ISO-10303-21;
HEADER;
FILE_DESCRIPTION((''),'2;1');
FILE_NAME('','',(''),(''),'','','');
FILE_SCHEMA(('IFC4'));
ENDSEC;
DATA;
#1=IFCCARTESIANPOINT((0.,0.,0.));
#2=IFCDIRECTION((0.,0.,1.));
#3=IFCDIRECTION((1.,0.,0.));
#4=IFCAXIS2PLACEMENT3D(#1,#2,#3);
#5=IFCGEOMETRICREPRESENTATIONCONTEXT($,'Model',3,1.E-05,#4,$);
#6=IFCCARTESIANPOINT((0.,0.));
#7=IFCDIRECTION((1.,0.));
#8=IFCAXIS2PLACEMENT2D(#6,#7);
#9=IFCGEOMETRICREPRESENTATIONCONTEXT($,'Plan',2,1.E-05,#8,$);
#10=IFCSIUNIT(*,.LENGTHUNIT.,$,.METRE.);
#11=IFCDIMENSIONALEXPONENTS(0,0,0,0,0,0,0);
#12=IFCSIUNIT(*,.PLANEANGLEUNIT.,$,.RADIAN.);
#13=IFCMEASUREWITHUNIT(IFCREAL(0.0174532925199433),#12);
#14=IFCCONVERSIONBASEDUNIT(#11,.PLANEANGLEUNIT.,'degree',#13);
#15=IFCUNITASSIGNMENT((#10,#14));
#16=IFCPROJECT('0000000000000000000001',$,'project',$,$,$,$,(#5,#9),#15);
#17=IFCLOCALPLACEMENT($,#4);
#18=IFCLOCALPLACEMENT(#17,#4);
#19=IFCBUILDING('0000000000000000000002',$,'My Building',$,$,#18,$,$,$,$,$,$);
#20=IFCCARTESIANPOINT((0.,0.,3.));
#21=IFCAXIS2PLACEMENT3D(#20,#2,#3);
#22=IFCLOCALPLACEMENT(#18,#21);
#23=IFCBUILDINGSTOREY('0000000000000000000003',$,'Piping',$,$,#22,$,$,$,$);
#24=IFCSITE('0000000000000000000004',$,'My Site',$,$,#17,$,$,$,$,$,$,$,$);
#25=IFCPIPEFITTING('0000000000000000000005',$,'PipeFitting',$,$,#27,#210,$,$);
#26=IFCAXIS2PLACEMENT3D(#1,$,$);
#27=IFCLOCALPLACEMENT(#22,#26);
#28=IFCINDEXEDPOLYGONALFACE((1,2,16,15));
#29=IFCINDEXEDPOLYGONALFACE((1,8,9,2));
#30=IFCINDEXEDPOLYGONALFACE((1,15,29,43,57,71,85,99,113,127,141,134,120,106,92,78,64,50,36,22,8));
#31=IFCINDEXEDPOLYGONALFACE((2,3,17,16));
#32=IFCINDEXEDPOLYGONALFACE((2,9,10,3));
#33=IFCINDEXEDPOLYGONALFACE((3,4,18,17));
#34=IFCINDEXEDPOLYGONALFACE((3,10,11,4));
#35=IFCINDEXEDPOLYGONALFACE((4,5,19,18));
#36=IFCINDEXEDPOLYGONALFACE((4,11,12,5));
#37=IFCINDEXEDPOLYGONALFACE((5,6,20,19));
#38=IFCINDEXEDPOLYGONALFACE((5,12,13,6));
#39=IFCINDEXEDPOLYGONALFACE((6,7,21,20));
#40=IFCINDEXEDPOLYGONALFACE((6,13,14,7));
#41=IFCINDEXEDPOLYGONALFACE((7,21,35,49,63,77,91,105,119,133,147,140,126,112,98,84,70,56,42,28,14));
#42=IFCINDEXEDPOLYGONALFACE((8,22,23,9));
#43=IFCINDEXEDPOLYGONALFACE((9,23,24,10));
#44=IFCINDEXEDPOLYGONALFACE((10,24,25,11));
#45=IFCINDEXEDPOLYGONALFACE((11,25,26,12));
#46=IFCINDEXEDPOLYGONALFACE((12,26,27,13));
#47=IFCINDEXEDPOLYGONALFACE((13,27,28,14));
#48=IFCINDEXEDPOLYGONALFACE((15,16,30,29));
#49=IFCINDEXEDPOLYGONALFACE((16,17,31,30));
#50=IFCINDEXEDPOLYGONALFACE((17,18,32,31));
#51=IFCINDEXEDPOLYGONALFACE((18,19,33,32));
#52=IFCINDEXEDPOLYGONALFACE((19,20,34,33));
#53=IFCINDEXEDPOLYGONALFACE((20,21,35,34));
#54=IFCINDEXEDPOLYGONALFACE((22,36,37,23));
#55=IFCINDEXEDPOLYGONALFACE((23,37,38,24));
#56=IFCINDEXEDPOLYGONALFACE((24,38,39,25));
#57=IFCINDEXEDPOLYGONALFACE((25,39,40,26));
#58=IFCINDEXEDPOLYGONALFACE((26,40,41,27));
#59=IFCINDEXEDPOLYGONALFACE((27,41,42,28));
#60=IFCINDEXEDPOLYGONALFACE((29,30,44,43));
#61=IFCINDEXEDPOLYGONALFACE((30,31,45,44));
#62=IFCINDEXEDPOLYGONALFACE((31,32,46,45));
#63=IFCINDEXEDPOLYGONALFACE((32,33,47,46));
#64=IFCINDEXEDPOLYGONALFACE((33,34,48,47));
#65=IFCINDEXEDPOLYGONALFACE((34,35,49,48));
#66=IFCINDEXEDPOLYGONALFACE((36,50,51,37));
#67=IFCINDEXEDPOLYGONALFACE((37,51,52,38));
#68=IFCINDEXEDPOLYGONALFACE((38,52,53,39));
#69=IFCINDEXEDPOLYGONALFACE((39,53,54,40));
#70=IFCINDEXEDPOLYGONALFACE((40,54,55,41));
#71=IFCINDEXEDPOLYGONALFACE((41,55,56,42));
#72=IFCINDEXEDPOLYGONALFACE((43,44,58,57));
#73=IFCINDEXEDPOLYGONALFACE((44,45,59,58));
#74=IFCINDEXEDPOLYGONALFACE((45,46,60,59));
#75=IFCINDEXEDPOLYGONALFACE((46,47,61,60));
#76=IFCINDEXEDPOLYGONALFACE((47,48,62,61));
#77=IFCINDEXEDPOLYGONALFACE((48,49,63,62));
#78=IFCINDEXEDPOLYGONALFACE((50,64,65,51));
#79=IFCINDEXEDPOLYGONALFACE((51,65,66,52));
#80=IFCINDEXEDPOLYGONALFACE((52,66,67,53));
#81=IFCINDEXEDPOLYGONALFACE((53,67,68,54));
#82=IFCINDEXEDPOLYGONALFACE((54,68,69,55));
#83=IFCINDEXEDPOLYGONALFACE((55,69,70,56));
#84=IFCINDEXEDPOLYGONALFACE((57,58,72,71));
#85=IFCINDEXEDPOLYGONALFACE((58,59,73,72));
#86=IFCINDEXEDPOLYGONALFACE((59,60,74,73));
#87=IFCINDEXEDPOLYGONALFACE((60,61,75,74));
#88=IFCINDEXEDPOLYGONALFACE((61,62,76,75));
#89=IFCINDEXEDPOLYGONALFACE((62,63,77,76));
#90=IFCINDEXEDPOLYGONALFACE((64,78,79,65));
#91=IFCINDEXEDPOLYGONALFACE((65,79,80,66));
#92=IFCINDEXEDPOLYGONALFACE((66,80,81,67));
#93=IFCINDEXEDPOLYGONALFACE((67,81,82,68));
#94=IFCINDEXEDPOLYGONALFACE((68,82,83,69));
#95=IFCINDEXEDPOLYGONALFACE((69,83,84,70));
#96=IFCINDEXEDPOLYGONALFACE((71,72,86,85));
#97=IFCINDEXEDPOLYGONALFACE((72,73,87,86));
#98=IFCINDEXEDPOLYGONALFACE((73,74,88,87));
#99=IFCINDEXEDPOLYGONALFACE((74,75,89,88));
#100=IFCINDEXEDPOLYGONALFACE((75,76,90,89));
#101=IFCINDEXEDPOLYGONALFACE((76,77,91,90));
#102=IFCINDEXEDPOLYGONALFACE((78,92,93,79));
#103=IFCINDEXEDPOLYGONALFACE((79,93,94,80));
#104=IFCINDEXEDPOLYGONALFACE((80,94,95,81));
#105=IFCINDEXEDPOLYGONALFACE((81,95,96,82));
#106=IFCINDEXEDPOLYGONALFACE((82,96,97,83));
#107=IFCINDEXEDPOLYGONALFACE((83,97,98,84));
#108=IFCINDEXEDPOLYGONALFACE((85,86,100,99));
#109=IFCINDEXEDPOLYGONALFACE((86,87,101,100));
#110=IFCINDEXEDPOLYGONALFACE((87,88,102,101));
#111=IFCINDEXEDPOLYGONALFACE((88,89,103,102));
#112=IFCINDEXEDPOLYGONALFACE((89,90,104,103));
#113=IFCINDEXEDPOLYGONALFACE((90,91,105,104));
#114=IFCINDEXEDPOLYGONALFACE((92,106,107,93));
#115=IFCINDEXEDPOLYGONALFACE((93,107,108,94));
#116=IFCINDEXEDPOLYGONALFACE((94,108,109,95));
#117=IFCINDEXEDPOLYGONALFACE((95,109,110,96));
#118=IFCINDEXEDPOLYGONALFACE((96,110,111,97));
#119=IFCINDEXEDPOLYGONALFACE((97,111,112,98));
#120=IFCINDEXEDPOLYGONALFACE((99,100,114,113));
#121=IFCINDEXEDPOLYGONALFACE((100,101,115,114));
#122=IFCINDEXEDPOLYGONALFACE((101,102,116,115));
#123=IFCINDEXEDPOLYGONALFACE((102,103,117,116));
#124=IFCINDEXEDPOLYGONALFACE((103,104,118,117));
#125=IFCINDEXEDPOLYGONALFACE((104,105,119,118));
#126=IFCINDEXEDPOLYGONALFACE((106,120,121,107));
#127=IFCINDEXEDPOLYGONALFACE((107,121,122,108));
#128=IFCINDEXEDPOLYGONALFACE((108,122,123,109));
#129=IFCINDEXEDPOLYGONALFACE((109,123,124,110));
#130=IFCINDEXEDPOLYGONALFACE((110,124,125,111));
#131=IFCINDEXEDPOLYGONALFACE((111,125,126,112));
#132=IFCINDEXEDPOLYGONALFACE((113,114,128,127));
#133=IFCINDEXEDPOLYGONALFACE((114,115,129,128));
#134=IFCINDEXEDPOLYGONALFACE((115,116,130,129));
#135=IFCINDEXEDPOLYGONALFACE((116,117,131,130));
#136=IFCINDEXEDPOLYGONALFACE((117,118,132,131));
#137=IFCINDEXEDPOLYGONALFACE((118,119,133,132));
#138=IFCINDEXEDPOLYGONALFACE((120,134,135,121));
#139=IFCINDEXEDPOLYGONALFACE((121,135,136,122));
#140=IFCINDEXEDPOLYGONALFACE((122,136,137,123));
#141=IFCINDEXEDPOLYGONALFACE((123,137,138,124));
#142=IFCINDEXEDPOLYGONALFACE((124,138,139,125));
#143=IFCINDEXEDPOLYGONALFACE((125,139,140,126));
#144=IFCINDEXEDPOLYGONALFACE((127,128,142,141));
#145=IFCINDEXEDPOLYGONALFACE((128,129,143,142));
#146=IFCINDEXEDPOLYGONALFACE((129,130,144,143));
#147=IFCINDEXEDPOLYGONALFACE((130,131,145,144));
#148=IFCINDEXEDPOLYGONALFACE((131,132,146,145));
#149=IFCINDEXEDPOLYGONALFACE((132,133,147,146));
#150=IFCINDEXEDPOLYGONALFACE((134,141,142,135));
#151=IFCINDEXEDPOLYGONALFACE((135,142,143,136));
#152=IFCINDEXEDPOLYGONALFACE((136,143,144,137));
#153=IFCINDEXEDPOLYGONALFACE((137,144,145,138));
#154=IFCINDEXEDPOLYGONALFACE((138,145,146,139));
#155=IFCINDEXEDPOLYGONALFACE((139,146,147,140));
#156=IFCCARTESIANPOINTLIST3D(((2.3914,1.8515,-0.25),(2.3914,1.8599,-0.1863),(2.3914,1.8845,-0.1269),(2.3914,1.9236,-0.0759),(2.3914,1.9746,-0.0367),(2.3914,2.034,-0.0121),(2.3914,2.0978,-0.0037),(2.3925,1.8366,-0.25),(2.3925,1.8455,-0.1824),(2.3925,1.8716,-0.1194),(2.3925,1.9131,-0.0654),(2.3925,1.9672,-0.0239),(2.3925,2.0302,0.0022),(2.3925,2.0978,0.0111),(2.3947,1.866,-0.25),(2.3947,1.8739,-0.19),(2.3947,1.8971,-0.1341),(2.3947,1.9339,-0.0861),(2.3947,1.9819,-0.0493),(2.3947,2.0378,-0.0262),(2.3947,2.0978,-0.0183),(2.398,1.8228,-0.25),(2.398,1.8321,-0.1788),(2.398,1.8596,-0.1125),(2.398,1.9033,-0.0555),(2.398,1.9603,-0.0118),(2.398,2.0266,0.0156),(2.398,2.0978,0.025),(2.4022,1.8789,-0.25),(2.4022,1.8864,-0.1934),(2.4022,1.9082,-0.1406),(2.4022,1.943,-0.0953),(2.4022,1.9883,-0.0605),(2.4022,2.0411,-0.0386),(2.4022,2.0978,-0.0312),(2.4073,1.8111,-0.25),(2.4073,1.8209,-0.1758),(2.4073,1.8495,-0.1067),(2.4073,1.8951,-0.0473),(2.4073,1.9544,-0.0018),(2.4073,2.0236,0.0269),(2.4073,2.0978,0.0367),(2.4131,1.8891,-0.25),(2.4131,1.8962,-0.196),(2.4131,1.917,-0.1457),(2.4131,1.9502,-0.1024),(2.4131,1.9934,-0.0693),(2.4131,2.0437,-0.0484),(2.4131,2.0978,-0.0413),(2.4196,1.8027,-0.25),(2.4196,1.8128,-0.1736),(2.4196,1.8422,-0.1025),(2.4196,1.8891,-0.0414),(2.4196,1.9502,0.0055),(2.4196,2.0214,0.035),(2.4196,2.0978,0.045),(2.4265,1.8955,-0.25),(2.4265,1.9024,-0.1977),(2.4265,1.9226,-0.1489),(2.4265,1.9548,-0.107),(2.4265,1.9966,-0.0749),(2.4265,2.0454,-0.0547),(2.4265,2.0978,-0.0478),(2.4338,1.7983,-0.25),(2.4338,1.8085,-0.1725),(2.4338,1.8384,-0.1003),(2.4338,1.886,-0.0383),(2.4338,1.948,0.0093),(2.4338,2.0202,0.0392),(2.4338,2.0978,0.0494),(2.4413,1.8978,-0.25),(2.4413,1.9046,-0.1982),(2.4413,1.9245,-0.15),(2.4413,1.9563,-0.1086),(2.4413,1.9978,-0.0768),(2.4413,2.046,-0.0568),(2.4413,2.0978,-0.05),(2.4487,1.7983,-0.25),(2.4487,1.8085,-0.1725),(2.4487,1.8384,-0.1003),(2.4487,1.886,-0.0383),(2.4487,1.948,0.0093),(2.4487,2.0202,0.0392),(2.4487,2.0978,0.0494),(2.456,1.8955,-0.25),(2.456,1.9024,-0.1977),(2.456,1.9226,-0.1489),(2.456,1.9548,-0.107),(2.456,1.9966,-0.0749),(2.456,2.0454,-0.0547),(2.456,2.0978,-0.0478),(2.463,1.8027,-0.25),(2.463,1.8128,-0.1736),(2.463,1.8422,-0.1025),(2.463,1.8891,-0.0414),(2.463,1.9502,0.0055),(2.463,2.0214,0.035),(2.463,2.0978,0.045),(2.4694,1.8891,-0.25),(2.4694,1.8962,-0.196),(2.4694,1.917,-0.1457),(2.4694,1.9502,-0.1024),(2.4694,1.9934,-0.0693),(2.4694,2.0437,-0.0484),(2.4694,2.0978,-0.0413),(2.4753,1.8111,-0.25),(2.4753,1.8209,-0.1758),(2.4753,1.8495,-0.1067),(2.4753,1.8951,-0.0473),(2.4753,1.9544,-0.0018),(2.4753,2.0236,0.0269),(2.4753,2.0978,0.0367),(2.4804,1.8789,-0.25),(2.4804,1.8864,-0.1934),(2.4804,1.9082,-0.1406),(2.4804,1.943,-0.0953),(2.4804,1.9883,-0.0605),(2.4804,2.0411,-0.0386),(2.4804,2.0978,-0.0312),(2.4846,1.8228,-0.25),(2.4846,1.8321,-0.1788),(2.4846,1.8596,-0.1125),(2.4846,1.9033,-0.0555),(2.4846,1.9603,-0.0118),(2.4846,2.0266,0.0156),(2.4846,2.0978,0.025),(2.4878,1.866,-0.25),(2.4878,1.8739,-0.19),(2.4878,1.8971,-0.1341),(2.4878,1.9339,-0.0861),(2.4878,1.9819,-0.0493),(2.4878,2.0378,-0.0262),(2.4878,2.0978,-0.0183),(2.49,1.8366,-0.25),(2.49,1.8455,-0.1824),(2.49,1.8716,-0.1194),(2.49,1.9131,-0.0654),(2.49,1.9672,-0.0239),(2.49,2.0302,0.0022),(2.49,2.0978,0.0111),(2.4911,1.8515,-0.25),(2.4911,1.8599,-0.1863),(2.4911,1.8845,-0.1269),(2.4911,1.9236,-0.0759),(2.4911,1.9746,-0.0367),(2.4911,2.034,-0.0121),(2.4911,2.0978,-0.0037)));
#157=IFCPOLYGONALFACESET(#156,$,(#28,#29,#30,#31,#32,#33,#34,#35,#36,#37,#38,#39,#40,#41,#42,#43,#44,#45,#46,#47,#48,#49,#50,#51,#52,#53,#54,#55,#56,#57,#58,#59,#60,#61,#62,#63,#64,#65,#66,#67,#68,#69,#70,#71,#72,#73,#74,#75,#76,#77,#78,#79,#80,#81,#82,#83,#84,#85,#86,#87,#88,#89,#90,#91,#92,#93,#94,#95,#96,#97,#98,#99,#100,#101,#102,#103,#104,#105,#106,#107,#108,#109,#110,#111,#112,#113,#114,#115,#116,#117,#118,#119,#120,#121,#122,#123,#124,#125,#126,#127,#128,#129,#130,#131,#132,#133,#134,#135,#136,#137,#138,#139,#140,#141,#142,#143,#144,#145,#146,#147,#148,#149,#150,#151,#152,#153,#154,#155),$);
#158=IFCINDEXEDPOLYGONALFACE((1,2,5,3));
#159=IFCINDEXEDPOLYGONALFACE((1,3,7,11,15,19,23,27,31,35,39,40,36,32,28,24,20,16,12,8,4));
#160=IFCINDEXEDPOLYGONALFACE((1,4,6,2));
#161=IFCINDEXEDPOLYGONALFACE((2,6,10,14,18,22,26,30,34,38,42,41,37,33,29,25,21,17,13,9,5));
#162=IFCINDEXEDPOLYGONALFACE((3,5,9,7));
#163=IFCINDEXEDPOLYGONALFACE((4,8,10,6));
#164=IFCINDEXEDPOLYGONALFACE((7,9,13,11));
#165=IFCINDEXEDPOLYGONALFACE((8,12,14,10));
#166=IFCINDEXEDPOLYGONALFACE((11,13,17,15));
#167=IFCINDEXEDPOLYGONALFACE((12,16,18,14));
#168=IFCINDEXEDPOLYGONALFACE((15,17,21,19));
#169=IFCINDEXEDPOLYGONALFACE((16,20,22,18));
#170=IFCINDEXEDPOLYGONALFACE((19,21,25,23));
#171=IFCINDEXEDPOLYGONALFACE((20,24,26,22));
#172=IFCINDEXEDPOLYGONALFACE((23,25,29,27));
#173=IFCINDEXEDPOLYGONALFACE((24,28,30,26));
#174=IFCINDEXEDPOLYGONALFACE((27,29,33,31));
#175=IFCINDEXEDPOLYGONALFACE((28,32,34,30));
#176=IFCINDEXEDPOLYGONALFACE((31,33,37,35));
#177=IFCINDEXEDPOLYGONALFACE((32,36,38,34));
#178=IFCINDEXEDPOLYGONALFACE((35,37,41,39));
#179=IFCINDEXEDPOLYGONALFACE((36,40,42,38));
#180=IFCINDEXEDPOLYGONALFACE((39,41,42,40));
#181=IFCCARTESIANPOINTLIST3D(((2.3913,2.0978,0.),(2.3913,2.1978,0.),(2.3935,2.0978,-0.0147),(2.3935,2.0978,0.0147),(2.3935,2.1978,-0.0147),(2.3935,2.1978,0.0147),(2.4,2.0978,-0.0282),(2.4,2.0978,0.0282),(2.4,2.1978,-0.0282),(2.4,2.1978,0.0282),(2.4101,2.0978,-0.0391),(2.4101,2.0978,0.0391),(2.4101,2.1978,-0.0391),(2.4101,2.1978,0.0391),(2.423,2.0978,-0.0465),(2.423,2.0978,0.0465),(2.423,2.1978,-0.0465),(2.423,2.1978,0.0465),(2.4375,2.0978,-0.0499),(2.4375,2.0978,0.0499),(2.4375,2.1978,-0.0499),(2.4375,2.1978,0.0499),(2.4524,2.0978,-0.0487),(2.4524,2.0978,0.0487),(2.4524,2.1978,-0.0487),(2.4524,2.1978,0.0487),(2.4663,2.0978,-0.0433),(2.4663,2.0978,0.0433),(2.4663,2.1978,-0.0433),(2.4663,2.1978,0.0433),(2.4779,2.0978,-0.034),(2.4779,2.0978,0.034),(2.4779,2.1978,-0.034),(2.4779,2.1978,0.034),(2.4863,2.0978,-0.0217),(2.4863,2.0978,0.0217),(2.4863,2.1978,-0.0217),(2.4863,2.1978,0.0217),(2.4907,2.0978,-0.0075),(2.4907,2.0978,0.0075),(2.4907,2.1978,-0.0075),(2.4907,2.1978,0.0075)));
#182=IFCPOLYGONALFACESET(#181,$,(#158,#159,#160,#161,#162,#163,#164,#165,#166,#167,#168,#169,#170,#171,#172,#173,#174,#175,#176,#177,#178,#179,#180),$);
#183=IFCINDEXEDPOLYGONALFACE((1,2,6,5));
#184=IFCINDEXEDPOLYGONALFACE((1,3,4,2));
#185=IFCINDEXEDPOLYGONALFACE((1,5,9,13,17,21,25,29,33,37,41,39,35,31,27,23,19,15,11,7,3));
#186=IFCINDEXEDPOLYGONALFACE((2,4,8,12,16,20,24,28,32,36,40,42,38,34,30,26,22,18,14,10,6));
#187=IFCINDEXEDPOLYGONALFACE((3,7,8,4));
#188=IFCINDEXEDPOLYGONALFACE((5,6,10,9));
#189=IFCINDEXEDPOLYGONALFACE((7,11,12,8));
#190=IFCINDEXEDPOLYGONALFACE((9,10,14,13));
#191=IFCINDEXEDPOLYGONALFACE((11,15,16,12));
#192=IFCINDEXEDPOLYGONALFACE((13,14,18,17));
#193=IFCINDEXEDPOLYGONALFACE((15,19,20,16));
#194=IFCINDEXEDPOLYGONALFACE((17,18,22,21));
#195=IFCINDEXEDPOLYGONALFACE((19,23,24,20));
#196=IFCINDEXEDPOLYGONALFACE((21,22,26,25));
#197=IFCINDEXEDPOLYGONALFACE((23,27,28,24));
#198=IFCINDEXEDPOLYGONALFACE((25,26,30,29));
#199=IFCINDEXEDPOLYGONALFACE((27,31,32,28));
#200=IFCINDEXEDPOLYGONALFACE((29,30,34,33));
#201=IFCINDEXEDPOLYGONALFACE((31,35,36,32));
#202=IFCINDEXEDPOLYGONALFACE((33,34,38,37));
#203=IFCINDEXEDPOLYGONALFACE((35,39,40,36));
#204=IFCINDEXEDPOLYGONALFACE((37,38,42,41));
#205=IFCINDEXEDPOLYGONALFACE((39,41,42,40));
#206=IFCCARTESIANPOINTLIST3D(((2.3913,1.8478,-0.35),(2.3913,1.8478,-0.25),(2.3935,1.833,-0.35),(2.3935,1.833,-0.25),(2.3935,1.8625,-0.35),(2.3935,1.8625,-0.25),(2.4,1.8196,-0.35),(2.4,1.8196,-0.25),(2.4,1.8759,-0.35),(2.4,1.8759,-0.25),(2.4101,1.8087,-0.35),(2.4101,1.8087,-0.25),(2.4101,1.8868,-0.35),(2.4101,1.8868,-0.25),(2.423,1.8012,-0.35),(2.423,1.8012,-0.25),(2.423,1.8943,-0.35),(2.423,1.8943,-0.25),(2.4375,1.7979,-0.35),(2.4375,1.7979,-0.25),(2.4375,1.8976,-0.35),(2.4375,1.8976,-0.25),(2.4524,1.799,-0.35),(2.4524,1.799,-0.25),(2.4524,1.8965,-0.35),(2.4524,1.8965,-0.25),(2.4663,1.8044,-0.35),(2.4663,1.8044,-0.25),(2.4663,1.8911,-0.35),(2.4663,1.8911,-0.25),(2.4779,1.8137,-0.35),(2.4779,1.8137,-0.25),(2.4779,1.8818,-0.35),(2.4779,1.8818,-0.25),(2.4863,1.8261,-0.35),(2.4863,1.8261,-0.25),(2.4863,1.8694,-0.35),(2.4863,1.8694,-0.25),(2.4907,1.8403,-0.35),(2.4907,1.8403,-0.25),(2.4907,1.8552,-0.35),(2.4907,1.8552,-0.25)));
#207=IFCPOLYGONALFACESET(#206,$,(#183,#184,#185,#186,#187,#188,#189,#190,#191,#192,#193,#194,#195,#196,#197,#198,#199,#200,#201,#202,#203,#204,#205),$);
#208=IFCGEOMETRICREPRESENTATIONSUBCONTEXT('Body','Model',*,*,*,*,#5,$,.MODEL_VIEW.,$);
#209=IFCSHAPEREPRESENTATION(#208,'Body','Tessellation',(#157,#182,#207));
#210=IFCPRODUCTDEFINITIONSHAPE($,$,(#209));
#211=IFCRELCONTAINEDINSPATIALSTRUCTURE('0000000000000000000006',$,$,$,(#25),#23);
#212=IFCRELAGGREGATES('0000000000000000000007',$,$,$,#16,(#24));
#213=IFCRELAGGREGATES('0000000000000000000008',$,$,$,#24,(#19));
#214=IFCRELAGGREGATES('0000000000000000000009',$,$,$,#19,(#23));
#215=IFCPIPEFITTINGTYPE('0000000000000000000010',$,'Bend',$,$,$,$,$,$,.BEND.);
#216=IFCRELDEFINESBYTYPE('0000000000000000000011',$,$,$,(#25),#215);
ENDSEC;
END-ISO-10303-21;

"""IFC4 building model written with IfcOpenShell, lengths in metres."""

from ifc_helpers import new_model, entity, si_unit, converted_unit, frame, origin_with_axes, origin_2d_with_axis, place, context, subcontext, project, spatial, circle, extrude, source, transform, mapped, type_object, type_shapes, element, save


model = new_model("IFC4")

# Units and contexts
model_context = context("Model", 3, precision=1e-05, world=origin_with_axes())
plan_context = context("Plan", 2, precision=1e-05, world=origin_2d_with_axis())
body_context = subcontext(model_context, "Body", "Model", "MODEL_VIEW")
ifc_project = project(units=[si_unit("LENGTHUNIT", "METRE"), converted_unit("PLANEANGLEUNIT", "degree", entity("IfcReal", 0.0174532925199433), si_unit("PLANEANGLEUNIT", "RADIAN"), dimensions=[0, 0, 0, 0, 0, 0, 0])], contexts=[model_context, plan_context])

# Site, building, storey
site_placement = place(None, origin_with_axes())
site = spatial("IfcSite", under=ifc_project, at=site_placement, Name="My Site")
building_placement = place(site_placement, origin_with_axes())
building = spatial("IfcBuilding", under=site, at=building_placement, Name="My Building")
storey_placement = place(building_placement, frame((0.0, 0.0, 3.0), z_axis=(0.0, 0.0, 1.0), x_axis=(1.0, 0.0, 0.0)))
storey = spatial("IfcBuildingStorey", under=building, at=storey_placement, Name="Piping")

# Pipe fitting
pipe_fitting_type = type_object("IfcPipeFittingType", Name="Bend", PredefinedType="BEND")
shared_shape = source(origin_with_axes(), body_context, "Body", "SolidModel", [
    entity("IfcSweptDiskSolid", entity("IfcIndexedPolyCurve", entity("IfcCartesianPointList3D", [[0.0, 0.0, -0.1], [0.0, -0.0732, -0.2768], [0.0, -0.25, -0.35]]), [entity("IfcArcIndex", [1, 2, 3])]), 0.05),
    extrude(circle(Radius=0.05), origin_with_axes(), (0.0, 0.0, -1.0), 0.1),
    extrude(circle(Radius=0.05), frame((0.0, -0.25, -0.35), z_axis=(0.0, -1.0, 0.0), x_axis=(1.0, 0.0, 0.0)), (0.0, 0.0, 1.0), 0.1),
])
type_shapes(pipe_fitting_type, [shared_shape])
for number, where, z_axis, x_axis, name in (
    (1, (2.4413, 2.1978, 0.0), (0.0, 1.0, 0.0), (-1.0, 0.0, 0.0), "PipeFitting"),
):
    element("IfcPipeFitting", number, at=place(storey_placement, frame(where, z_axis=z_axis, x_axis=x_axis)), inside=storey, type_object=pipe_fitting_type, Name=name, context=body_context, shape_type="MappedRepresentation", body=[
        mapped(shared_shape, transform((0.0, 0.0, 0.0), x_axis=(1.0, 0.0, 0.0), y_axis=(0.0, 1.0, 0.0), z_axis=(0.0, 0.0, 1.0), scale=1.0)),
    ])

save(model, "model.ifc")
